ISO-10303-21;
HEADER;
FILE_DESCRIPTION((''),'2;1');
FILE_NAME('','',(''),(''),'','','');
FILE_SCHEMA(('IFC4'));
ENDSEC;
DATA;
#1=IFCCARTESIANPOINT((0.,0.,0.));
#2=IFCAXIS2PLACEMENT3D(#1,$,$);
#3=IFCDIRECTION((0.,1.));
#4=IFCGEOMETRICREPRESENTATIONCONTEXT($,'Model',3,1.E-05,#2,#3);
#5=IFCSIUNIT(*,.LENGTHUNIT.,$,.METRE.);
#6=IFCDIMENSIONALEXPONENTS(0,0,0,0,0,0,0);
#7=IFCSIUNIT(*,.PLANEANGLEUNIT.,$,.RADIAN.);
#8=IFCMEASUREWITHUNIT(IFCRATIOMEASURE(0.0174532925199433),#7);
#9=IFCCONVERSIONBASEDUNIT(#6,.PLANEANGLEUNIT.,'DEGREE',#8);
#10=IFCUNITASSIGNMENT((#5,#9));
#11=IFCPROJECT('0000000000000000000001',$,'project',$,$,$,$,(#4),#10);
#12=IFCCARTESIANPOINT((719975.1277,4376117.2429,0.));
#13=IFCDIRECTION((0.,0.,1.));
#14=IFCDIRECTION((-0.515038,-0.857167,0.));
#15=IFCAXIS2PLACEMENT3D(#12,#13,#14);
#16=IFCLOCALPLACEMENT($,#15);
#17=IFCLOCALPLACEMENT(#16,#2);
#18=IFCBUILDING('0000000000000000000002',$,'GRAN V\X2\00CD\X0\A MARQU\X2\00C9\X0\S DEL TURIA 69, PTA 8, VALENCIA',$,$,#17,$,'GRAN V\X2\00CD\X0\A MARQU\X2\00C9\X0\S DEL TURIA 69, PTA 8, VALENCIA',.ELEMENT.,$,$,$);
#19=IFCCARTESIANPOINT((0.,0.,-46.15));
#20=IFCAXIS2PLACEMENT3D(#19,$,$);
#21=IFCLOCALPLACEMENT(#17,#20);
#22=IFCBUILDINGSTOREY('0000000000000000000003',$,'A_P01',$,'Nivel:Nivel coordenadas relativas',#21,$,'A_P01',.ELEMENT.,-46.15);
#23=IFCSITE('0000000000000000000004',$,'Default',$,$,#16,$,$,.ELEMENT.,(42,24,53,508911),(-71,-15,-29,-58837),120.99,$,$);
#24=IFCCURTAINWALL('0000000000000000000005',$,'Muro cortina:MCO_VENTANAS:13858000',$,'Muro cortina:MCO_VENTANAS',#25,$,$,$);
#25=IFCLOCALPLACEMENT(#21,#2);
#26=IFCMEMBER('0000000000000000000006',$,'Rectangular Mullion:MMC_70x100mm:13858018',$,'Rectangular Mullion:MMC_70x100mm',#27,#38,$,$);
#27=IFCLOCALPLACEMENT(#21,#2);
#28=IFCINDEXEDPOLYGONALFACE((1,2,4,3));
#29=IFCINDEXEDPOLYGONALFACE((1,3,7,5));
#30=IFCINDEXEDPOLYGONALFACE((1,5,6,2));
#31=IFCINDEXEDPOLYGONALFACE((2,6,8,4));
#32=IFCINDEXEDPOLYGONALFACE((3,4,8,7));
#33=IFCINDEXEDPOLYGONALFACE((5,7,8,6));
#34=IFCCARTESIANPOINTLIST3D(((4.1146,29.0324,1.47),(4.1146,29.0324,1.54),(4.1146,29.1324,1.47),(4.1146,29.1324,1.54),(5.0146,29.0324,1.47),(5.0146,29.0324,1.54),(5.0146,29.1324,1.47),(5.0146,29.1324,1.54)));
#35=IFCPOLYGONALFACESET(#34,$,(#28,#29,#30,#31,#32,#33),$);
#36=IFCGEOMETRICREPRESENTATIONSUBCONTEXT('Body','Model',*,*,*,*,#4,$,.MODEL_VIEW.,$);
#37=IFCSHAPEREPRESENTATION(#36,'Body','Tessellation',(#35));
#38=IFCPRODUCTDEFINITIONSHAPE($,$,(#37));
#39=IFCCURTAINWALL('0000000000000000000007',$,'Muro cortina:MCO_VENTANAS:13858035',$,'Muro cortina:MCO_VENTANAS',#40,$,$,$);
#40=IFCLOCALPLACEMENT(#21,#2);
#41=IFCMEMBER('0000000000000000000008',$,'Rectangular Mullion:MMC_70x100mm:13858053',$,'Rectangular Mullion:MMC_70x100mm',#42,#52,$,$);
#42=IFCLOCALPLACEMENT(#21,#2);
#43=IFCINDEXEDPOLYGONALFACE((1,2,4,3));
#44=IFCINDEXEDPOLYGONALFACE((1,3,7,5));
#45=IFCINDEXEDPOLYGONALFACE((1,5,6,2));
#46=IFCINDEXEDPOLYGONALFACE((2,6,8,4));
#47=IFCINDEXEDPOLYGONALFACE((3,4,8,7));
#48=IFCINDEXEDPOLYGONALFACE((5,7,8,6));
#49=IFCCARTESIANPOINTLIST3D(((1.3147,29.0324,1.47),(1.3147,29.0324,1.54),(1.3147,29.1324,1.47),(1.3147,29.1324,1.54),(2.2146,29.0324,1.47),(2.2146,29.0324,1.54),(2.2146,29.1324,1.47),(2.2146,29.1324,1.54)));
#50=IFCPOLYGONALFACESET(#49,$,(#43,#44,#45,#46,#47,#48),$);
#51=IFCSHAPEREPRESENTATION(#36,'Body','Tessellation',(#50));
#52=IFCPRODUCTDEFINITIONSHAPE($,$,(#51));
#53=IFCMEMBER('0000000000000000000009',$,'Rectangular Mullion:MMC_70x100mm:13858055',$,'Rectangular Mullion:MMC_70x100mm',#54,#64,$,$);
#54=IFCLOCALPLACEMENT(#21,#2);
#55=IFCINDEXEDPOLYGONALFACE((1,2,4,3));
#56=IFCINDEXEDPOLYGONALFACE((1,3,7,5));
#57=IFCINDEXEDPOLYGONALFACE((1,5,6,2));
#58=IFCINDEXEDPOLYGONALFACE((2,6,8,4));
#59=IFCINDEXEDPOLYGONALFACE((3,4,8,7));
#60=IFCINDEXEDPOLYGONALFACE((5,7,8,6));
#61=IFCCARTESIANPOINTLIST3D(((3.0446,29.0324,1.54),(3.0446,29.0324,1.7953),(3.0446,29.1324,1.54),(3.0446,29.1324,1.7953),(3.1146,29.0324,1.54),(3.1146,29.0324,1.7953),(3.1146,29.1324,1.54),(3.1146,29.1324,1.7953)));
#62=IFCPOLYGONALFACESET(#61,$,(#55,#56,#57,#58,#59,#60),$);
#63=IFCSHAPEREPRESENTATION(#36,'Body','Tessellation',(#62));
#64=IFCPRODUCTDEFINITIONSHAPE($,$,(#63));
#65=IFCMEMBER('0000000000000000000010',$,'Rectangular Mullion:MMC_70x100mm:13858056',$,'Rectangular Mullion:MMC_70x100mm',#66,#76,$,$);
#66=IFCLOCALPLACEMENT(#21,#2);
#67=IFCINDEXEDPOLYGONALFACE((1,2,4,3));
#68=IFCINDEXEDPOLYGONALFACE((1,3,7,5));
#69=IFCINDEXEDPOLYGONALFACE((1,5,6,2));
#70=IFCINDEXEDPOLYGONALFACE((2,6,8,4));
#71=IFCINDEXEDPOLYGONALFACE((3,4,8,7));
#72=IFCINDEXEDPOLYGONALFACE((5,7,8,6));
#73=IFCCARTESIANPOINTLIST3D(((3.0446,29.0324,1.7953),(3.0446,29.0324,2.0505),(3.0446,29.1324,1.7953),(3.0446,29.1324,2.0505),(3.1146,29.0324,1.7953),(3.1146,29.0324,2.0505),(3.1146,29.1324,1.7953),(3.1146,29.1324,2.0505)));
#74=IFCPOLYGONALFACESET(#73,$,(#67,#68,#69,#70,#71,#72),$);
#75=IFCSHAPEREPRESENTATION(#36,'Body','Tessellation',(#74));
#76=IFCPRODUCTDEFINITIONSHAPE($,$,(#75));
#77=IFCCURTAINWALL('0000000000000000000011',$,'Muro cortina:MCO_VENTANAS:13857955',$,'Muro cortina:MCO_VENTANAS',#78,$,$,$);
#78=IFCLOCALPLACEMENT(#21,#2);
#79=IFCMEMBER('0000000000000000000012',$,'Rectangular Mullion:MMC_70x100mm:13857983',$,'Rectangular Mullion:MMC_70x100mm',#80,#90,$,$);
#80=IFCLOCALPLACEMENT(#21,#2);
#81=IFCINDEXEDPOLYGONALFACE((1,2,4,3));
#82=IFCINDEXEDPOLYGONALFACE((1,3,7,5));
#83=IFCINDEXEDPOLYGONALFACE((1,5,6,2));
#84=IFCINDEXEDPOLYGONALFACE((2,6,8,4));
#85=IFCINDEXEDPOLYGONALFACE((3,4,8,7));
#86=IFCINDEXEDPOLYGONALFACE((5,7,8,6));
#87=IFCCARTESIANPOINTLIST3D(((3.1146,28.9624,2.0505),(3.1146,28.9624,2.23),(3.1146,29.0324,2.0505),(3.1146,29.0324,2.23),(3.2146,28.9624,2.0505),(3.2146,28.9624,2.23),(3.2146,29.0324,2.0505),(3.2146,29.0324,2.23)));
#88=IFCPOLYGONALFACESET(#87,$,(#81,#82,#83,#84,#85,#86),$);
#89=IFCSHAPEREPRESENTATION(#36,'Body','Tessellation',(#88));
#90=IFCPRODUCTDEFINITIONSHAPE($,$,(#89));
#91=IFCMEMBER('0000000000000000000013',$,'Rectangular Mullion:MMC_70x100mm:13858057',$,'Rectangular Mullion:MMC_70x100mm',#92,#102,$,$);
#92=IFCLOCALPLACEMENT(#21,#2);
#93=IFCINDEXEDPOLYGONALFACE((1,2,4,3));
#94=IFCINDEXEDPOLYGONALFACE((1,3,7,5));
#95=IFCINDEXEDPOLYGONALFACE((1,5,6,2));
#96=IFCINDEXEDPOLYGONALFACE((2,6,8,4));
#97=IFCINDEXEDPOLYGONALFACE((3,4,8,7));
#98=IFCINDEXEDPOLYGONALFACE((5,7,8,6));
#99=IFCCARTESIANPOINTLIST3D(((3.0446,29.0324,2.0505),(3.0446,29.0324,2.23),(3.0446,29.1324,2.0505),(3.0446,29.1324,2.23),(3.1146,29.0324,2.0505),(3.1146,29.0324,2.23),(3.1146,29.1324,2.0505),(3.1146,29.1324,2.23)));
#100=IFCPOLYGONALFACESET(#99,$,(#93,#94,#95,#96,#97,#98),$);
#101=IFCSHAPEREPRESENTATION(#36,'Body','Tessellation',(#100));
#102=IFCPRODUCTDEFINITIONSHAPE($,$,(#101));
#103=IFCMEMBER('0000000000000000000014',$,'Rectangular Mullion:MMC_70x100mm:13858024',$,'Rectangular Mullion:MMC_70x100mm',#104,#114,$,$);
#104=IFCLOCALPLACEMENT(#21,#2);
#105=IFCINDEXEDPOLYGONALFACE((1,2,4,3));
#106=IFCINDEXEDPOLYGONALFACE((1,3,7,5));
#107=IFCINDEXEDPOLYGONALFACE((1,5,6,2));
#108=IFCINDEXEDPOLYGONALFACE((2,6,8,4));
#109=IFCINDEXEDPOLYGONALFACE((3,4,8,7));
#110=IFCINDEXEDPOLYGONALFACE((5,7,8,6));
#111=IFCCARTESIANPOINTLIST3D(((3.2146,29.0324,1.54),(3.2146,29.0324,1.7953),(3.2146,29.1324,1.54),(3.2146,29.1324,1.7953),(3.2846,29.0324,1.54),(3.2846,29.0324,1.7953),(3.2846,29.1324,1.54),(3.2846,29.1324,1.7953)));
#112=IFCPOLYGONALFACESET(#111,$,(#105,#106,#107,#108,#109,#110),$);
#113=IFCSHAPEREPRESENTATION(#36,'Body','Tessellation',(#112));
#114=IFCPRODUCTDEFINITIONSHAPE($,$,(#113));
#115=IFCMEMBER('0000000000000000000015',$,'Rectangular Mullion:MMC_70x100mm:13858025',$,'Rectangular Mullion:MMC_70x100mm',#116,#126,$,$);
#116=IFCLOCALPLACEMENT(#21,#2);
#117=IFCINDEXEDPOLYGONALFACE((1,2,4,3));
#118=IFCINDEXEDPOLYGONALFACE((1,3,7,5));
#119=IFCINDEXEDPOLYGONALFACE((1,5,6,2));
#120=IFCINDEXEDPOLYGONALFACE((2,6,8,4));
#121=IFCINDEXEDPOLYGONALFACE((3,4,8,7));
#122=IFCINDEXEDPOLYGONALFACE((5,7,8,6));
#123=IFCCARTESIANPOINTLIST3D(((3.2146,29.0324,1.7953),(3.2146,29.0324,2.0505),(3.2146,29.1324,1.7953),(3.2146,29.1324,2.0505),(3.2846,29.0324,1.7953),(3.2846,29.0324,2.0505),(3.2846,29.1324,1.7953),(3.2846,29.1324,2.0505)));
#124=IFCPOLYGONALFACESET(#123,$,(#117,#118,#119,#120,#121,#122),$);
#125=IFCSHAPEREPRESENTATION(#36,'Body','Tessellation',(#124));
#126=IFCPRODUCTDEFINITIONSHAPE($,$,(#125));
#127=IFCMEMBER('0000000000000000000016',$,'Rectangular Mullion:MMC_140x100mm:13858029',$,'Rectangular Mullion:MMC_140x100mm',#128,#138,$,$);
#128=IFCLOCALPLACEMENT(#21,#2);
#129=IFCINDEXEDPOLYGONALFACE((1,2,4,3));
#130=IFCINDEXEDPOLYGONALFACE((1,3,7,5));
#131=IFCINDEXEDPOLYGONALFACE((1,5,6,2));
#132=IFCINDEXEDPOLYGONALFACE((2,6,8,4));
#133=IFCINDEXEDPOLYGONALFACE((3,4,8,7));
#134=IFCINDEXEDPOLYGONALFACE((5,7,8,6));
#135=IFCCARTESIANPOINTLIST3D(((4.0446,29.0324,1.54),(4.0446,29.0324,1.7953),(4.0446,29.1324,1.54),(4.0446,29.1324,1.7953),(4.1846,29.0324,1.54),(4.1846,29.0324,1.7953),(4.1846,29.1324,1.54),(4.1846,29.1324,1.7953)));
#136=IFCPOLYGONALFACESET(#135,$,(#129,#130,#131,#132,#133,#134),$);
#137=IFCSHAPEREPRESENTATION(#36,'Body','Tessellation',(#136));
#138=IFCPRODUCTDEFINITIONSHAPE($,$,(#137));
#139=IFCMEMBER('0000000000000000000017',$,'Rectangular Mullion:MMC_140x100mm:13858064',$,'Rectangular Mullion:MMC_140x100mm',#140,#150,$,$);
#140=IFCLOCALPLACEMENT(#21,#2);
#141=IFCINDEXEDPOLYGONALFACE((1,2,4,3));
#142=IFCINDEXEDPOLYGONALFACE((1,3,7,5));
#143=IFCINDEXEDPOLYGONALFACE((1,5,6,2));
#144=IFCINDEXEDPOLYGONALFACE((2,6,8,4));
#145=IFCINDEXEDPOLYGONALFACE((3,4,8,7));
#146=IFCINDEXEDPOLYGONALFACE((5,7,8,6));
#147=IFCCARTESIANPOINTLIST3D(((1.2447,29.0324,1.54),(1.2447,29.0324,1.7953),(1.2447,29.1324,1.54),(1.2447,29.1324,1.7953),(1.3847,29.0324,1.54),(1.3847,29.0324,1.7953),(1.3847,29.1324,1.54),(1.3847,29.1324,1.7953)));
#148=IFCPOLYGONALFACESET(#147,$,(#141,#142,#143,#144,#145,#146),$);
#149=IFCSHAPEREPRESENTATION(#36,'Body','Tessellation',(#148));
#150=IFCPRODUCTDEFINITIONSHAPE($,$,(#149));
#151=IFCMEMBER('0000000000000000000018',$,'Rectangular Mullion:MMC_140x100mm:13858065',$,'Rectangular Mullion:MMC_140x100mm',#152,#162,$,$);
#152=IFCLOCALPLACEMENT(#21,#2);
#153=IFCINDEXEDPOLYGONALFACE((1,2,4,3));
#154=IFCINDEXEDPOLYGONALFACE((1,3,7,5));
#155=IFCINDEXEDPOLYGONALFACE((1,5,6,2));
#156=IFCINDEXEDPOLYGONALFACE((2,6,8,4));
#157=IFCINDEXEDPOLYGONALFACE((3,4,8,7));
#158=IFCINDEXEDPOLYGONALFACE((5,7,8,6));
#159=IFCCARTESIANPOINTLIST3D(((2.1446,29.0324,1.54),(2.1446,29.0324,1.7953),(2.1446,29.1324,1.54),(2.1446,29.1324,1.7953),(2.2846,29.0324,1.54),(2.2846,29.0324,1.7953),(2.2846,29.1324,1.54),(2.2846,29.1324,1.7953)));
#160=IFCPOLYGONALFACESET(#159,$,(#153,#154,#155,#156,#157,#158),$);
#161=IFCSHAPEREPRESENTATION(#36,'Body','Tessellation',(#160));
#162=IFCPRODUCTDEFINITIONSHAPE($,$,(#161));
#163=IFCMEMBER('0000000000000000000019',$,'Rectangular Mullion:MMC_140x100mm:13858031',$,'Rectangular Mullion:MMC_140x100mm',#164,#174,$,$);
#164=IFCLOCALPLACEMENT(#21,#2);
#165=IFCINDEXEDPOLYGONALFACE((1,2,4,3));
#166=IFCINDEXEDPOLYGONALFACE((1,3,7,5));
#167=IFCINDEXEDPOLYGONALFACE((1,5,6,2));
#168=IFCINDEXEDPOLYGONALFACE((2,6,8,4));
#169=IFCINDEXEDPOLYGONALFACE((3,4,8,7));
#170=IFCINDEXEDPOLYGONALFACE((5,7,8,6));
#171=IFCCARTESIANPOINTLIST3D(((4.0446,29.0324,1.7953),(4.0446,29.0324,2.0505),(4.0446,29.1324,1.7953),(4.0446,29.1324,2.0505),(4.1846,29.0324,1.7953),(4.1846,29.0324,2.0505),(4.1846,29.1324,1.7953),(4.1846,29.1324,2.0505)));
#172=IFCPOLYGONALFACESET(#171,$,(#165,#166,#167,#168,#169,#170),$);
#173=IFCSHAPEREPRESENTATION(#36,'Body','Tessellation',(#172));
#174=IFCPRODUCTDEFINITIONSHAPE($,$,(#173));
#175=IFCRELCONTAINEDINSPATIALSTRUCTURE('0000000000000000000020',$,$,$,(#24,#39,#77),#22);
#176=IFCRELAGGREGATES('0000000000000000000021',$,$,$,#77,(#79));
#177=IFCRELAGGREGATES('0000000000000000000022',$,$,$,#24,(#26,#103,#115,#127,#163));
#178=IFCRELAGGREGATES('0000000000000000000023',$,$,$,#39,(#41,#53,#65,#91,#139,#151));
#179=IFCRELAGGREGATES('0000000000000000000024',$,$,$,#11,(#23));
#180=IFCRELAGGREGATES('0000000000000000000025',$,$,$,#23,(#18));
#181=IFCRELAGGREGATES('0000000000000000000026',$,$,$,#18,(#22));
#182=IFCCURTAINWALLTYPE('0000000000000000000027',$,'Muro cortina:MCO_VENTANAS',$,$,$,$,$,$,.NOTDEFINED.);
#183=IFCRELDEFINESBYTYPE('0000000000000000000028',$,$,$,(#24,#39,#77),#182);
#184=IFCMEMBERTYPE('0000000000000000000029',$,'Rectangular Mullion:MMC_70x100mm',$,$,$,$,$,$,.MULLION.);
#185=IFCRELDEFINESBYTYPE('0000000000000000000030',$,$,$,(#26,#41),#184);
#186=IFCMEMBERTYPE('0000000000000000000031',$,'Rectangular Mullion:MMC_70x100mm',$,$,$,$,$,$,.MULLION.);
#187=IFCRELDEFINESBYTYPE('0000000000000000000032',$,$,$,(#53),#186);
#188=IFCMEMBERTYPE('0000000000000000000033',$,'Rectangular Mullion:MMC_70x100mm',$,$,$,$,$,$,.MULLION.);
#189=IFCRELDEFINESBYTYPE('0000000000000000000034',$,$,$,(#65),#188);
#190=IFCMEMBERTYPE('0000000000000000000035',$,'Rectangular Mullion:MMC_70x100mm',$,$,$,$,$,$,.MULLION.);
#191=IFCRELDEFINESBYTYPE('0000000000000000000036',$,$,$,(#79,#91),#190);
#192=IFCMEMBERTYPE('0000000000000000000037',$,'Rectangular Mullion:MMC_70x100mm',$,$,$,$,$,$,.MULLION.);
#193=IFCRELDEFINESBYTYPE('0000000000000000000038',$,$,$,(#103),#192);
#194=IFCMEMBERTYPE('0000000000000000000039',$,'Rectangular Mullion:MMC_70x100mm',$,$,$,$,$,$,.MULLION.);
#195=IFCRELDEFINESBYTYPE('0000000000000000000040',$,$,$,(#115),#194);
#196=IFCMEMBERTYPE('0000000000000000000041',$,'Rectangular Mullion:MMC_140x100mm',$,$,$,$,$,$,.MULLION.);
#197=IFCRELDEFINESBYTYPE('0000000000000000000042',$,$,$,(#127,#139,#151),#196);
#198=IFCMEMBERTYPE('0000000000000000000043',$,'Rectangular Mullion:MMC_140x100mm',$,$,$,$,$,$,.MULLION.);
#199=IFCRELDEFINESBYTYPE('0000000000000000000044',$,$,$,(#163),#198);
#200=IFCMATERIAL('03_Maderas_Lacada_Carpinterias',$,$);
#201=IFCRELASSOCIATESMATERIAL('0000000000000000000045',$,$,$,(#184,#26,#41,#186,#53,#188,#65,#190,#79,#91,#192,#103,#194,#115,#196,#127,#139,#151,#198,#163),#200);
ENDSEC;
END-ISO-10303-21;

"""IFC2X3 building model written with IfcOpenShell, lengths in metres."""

from ifc_helpers import new_model, entity, si_unit, converted_unit, direction, frame, origin, origin_2d_with_axis, place, context, subcontext, project, spatial, rectangle, extrude, source, transform, mapped, material, type_object, type_shapes, element, aggregate, save


model = new_model("IFC2X3")

# Units and contexts
model_context = context("Model", 3, precision=1e-05, world=origin(), true_north=direction((0.0, 1.0)))
body_context = subcontext(model_context, "Body", "Model", "MODEL_VIEW")
ifc_project = project(units=[si_unit("LENGTHUNIT", "METRE"), converted_unit("PLANEANGLEUNIT", "DEGREE", entity("IfcRatioMeasure", 0.0174532925199433), si_unit("PLANEANGLEUNIT", "RADIAN"), dimensions=[0, 0, 0, 0, 0, 0, 0])], contexts=[model_context])

# Site, building, storey
site_placement = place(None, frame((719975.1277, 4376117.2429, 0.0), z_axis=(0.0, 0.0, 1.0), x_axis=(-0.515038, -0.857167, 0.0)))
site = spatial("IfcSite", under=ifc_project, at=site_placement, Name="Default", CompositionType="ELEMENT", RefLatitude=(42, 24, 53, 508911), RefLongitude=(-71, -15, -29, -58837), RefElevation=120.99)
building_placement = place(site_placement, origin())
building = spatial("IfcBuilding", under=site, at=building_placement, Name="GRAN VÍA MARQUÉS DEL TURIA 69, PTA 8, VALENCIA", LongName="GRAN VÍA MARQUÉS DEL TURIA 69, PTA 8, VALENCIA", CompositionType="ELEMENT")
storey_placement = place(building_placement, frame((0.0, 0.0, -46.15)))
storey = spatial("IfcBuildingStorey", under=building, at=storey_placement, Name="A_P01", ObjectType="Nivel:Nivel coordenadas relativas", LongName="A_P01", CompositionType="ELEMENT", Elevation=-46.15)

# Curtain wall, member
curtain_wall_type = type_object("IfcCurtainWallType", Name="Muro cortina:MCO_VENTANAS", PredefinedType="NOTDEFINED")
curtain_wall_1_placement = place(storey_placement, frame((0.0, 0.0, 46.15)))
curtain_wall_1 = element("IfcCurtainWall", 1, at=curtain_wall_1_placement, inside=storey, type_object=curtain_wall_type, Name="Muro cortina:MCO_VENTANAS:13858000", ObjectType="Muro cortina:MCO_VENTANAS")
ifc_material_1 = material(Name="03_Maderas_Lacada_Carpinterias")
member_type_1 = type_object("IfcMemberType", Name="Rectangular Mullion:MMC_70x100mm", PredefinedType="MULLION", material=ifc_material_1)
shared_shape_1 = source(origin(), body_context, "Body", "SweptSolid", [
    extrude(rectangle(XDim=0.1, YDim=0.07, at=origin_2d_with_axis()), frame((-0.035, 0.0, -0.9), z_axis=(0.0, 0.0, 1.0), x_axis=(0.0, -1.0, 0.0)), (0.0, 0.0, 1.0), 0.9),
])
type_shapes(member_type_1, [shared_shape_1])
member_1_placement = place(storey_placement, frame((4.1146, 29.0824, 1.47), z_axis=(-1.0, 0.0, 0.0), x_axis=(0.0, 0.0, -1.0)))
member_1 = element("IfcMember", 2, at=member_1_placement, type_object=member_type_1, material=ifc_material_1, Name="Rectangular Mullion:MMC_70x100mm:13858018", ObjectType="Rectangular Mullion:MMC_70x100mm", context=body_context, shape_type="MappedRepresentation", body=[
    mapped(shared_shape_1, transform((0.0, 0.0, 0.0), scale=1.0)),
])

# Curtain wall, members
curtain_wall_2_placement = place(storey_placement, frame((0.0, 0.0, 46.15)))
curtain_wall_2 = element("IfcCurtainWall", 3, at=curtain_wall_2_placement, inside=storey, type_object=curtain_wall_type, Name="Muro cortina:MCO_VENTANAS:13858035", ObjectType="Muro cortina:MCO_VENTANAS")
member_2_placement = place(storey_placement, frame((1.3147, 29.0824, 1.47), z_axis=(-1.0, 0.0, 0.0), x_axis=(0.0, 0.0, -1.0)))
member_2 = element("IfcMember", 4, at=member_2_placement, type_object=member_type_1, material=ifc_material_1, Name="Rectangular Mullion:MMC_70x100mm:13858053", ObjectType="Rectangular Mullion:MMC_70x100mm", context=body_context, shape_type="MappedRepresentation", body=[
    mapped(shared_shape_1, transform((0.0, 0.0, 0.0), scale=1.0)),
])
member_type_2 = type_object("IfcMemberType", Name="Rectangular Mullion:MMC_70x100mm", PredefinedType="MULLION", material=ifc_material_1)
shared_shape_2 = source(origin(), body_context, "Body", "SweptSolid", [
    extrude(rectangle(XDim=0.1, YDim=0.07, at=origin_2d_with_axis()), frame((-0.035, 0.0, -0.2552), z_axis=(0.0, 0.0, 1.0), x_axis=(0.0, -1.0, 0.0)), (0.0, 0.0, 1.0), 0.2552),
])
type_shapes(member_type_2, [shared_shape_2])
member_3_placement = place(storey_placement, frame((3.1146, 29.0824, 1.54), z_axis=(0.0, 0.0, -1.0), x_axis=(1.0, 0.0, 0.0)))
member_3 = element("IfcMember", 5, at=member_3_placement, type_object=member_type_2, material=ifc_material_1, Name="Rectangular Mullion:MMC_70x100mm:13858055", ObjectType="Rectangular Mullion:MMC_70x100mm", context=body_context, shape_type="MappedRepresentation", body=[
    mapped(shared_shape_2, transform((0.0, 0.0, 0.0), scale=1.0)),
])
member_type_3 = type_object("IfcMemberType", Name="Rectangular Mullion:MMC_70x100mm", PredefinedType="MULLION", material=ifc_material_1)
shared_shape_3 = source(origin(), body_context, "Body", "SweptSolid", [
    extrude(rectangle(XDim=0.1, YDim=0.07, at=origin_2d_with_axis()), frame((-0.035, 0.0, -0.2552), z_axis=(0.0, 0.0, 1.0), x_axis=(0.0, -1.0, 0.0)), (0.0, 0.0, 1.0), 0.2552),
])
type_shapes(member_type_3, [shared_shape_3])
member_4_placement = place(storey_placement, frame((3.1146, 29.0824, 1.7953), z_axis=(0.0, 0.0, -1.0), x_axis=(1.0, 0.0, 0.0)))
member_4 = element("IfcMember", 6, at=member_4_placement, type_object=member_type_3, material=ifc_material_1, Name="Rectangular Mullion:MMC_70x100mm:13858056", ObjectType="Rectangular Mullion:MMC_70x100mm", context=body_context, shape_type="MappedRepresentation", body=[
    mapped(shared_shape_3, transform((0.0, 0.0, 0.0), scale=1.0)),
])

# Curtain wall, member
curtain_wall_3_placement = place(storey_placement, frame((0.0, 0.0, 46.15)))
curtain_wall_3 = element("IfcCurtainWall", 7, at=curtain_wall_3_placement, inside=storey, type_object=curtain_wall_type, Name="Muro cortina:MCO_VENTANAS:13857955", ObjectType="Muro cortina:MCO_VENTANAS")
member_type_4 = type_object("IfcMemberType", Name="Rectangular Mullion:MMC_70x100mm", PredefinedType="MULLION", material=ifc_material_1)
shared_shape_4 = source(origin(), body_context, "Body", "SweptSolid", [
    extrude(rectangle(XDim=0.1, YDim=0.07, at=origin_2d_with_axis()), frame((-0.035, 0.0, -0.1795), z_axis=(0.0, 0.0, 1.0), x_axis=(0.0, -1.0, 0.0)), (0.0, 0.0, 1.0), 0.1795),
])
type_shapes(member_type_4, [shared_shape_4])
member_5_placement = place(storey_placement, frame((3.1646, 29.0324, 2.0505), z_axis=(0.0, 0.0, -1.0), x_axis=(0.0, 1.0, 0.0)))
member_5 = element("IfcMember", 8, at=member_5_placement, type_object=member_type_4, material=ifc_material_1, Name="Rectangular Mullion:MMC_70x100mm:13857983", ObjectType="Rectangular Mullion:MMC_70x100mm", context=body_context, shape_type="MappedRepresentation", body=[
    mapped(shared_shape_4, transform((0.0, 0.0, 0.0), scale=1.0)),
])

# Members
member_6_placement = place(storey_placement, frame((3.1146, 29.0824, 2.0505), z_axis=(0.0, 0.0, -1.0), x_axis=(1.0, 0.0, 0.0)))
member_6 = element("IfcMember", 9, at=member_6_placement, type_object=member_type_4, material=ifc_material_1, Name="Rectangular Mullion:MMC_70x100mm:13858057", ObjectType="Rectangular Mullion:MMC_70x100mm", context=body_context, shape_type="MappedRepresentation", body=[
    mapped(shared_shape_4, transform((0.0, 0.0, 0.0), scale=1.0)),
])
member_type_5 = type_object("IfcMemberType", Name="Rectangular Mullion:MMC_70x100mm", PredefinedType="MULLION", material=ifc_material_1)
shared_shape_5 = source(origin(), body_context, "Body", "SweptSolid", [
    extrude(rectangle(XDim=0.1, YDim=0.07, at=origin_2d_with_axis()), frame((-0.035, 0.0, -0.2552), z_axis=(0.0, 0.0, 1.0), x_axis=(0.0, -1.0, 0.0)), (0.0, 0.0, 1.0), 0.2552),
])
type_shapes(member_type_5, [shared_shape_5])
member_7_placement = place(storey_placement, frame((3.2146, 29.0824, 1.7953), z_axis=(0.0, 0.0, 1.0), x_axis=(-1.0, 0.0, 0.0)))
member_7 = element("IfcMember", 10, at=member_7_placement, type_object=member_type_5, material=ifc_material_1, Name="Rectangular Mullion:MMC_70x100mm:13858024", ObjectType="Rectangular Mullion:MMC_70x100mm", context=body_context, shape_type="MappedRepresentation", body=[
    mapped(shared_shape_5, transform((0.0, 0.0, 0.0), scale=1.0)),
])
member_type_6 = type_object("IfcMemberType", Name="Rectangular Mullion:MMC_70x100mm", PredefinedType="MULLION", material=ifc_material_1)
shared_shape_6 = source(origin(), body_context, "Body", "SweptSolid", [
    extrude(rectangle(XDim=0.1, YDim=0.07, at=origin_2d_with_axis()), frame((-0.035, 0.0, -0.2552), z_axis=(0.0, 0.0, 1.0), x_axis=(0.0, -1.0, 0.0)), (0.0, 0.0, 1.0), 0.2552),
])
type_shapes(member_type_6, [shared_shape_6])
member_8_placement = place(storey_placement, frame((3.2146, 29.0824, 2.0505), z_axis=(0.0, 0.0, 1.0), x_axis=(-1.0, 0.0, 0.0)))
member_8 = element("IfcMember", 11, at=member_8_placement, type_object=member_type_6, material=ifc_material_1, Name="Rectangular Mullion:MMC_70x100mm:13858025", ObjectType="Rectangular Mullion:MMC_70x100mm", context=body_context, shape_type="MappedRepresentation", body=[
    mapped(shared_shape_6, transform((0.0, 0.0, 0.0), scale=1.0)),
])
member_type_7 = type_object("IfcMemberType", Name="Rectangular Mullion:MMC_140x100mm", PredefinedType="MULLION", material=ifc_material_1)
shared_shape_7 = source(origin(), body_context, "Body", "SweptSolid", [
    extrude(rectangle(XDim=0.1, YDim=0.14, at=origin_2d_with_axis()), frame((0.0, 0.0, -0.2552), z_axis=(0.0, 0.0, 1.0), x_axis=(0.0, -1.0, 0.0)), (0.0, 0.0, 1.0), 0.2552),
])
type_shapes(member_type_7, [shared_shape_7])
member_9_placement = place(storey_placement, frame((4.1146, 29.0824, 1.54), z_axis=(0.0, 0.0, -1.0), x_axis=(1.0, 0.0, 0.0)))
member_9 = element("IfcMember", 12, at=member_9_placement, type_object=member_type_7, material=ifc_material_1, Name="Rectangular Mullion:MMC_140x100mm:13858029", ObjectType="Rectangular Mullion:MMC_140x100mm", context=body_context, shape_type="MappedRepresentation", body=[
    mapped(shared_shape_7, transform((0.0, 0.0, 0.0), scale=1.0)),
])
member_10_placement = place(storey_placement, frame((1.3147, 29.0824, 1.54), z_axis=(0.0, 0.0, -1.0), x_axis=(1.0, 0.0, 0.0)))
member_10 = element("IfcMember", 13, at=member_10_placement, type_object=member_type_7, material=ifc_material_1, Name="Rectangular Mullion:MMC_140x100mm:13858064", ObjectType="Rectangular Mullion:MMC_140x100mm", context=body_context, shape_type="MappedRepresentation", body=[
    mapped(shared_shape_7, transform((0.0, 0.0, 0.0), scale=1.0)),
])
member_11_placement = place(storey_placement, frame((2.2146, 29.0824, 1.54), z_axis=(0.0, 0.0, -1.0), x_axis=(1.0, 0.0, 0.0)))
member_11 = element("IfcMember", 14, at=member_11_placement, type_object=member_type_7, material=ifc_material_1, Name="Rectangular Mullion:MMC_140x100mm:13858065", ObjectType="Rectangular Mullion:MMC_140x100mm", context=body_context, shape_type="MappedRepresentation", body=[
    mapped(shared_shape_7, transform((0.0, 0.0, 0.0), scale=1.0)),
])
member_type_8 = type_object("IfcMemberType", Name="Rectangular Mullion:MMC_140x100mm", PredefinedType="MULLION", material=ifc_material_1)
shared_shape_8 = source(origin(), body_context, "Body", "SweptSolid", [
    extrude(rectangle(XDim=0.1, YDim=0.14, at=origin_2d_with_axis()), frame((0.0, 0.0, -0.2552), z_axis=(0.0, 0.0, 1.0), x_axis=(0.0, -1.0, 0.0)), (0.0, 0.0, 1.0), 0.2552),
])
type_shapes(member_type_8, [shared_shape_8])
member_12_placement = place(storey_placement, frame((4.1146, 29.0824, 1.7953), z_axis=(0.0, 0.0, -1.0), x_axis=(1.0, 0.0, 0.0)))
member_12 = element("IfcMember", 15, at=member_12_placement, type_object=member_type_8, material=ifc_material_1, Name="Rectangular Mullion:MMC_140x100mm:13858031", ObjectType="Rectangular Mullion:MMC_140x100mm", context=body_context, shape_type="MappedRepresentation", body=[
    mapped(shared_shape_8, transform((0.0, 0.0, 0.0), scale=1.0)),
])

aggregate(curtain_wall_3, [member_5])
aggregate(curtain_wall_1, [member_1, member_7, member_8, member_9, member_12])
aggregate(curtain_wall_2, [member_2, member_3, member_4, member_6, member_10, member_11])

save(model, "model.ifc")
